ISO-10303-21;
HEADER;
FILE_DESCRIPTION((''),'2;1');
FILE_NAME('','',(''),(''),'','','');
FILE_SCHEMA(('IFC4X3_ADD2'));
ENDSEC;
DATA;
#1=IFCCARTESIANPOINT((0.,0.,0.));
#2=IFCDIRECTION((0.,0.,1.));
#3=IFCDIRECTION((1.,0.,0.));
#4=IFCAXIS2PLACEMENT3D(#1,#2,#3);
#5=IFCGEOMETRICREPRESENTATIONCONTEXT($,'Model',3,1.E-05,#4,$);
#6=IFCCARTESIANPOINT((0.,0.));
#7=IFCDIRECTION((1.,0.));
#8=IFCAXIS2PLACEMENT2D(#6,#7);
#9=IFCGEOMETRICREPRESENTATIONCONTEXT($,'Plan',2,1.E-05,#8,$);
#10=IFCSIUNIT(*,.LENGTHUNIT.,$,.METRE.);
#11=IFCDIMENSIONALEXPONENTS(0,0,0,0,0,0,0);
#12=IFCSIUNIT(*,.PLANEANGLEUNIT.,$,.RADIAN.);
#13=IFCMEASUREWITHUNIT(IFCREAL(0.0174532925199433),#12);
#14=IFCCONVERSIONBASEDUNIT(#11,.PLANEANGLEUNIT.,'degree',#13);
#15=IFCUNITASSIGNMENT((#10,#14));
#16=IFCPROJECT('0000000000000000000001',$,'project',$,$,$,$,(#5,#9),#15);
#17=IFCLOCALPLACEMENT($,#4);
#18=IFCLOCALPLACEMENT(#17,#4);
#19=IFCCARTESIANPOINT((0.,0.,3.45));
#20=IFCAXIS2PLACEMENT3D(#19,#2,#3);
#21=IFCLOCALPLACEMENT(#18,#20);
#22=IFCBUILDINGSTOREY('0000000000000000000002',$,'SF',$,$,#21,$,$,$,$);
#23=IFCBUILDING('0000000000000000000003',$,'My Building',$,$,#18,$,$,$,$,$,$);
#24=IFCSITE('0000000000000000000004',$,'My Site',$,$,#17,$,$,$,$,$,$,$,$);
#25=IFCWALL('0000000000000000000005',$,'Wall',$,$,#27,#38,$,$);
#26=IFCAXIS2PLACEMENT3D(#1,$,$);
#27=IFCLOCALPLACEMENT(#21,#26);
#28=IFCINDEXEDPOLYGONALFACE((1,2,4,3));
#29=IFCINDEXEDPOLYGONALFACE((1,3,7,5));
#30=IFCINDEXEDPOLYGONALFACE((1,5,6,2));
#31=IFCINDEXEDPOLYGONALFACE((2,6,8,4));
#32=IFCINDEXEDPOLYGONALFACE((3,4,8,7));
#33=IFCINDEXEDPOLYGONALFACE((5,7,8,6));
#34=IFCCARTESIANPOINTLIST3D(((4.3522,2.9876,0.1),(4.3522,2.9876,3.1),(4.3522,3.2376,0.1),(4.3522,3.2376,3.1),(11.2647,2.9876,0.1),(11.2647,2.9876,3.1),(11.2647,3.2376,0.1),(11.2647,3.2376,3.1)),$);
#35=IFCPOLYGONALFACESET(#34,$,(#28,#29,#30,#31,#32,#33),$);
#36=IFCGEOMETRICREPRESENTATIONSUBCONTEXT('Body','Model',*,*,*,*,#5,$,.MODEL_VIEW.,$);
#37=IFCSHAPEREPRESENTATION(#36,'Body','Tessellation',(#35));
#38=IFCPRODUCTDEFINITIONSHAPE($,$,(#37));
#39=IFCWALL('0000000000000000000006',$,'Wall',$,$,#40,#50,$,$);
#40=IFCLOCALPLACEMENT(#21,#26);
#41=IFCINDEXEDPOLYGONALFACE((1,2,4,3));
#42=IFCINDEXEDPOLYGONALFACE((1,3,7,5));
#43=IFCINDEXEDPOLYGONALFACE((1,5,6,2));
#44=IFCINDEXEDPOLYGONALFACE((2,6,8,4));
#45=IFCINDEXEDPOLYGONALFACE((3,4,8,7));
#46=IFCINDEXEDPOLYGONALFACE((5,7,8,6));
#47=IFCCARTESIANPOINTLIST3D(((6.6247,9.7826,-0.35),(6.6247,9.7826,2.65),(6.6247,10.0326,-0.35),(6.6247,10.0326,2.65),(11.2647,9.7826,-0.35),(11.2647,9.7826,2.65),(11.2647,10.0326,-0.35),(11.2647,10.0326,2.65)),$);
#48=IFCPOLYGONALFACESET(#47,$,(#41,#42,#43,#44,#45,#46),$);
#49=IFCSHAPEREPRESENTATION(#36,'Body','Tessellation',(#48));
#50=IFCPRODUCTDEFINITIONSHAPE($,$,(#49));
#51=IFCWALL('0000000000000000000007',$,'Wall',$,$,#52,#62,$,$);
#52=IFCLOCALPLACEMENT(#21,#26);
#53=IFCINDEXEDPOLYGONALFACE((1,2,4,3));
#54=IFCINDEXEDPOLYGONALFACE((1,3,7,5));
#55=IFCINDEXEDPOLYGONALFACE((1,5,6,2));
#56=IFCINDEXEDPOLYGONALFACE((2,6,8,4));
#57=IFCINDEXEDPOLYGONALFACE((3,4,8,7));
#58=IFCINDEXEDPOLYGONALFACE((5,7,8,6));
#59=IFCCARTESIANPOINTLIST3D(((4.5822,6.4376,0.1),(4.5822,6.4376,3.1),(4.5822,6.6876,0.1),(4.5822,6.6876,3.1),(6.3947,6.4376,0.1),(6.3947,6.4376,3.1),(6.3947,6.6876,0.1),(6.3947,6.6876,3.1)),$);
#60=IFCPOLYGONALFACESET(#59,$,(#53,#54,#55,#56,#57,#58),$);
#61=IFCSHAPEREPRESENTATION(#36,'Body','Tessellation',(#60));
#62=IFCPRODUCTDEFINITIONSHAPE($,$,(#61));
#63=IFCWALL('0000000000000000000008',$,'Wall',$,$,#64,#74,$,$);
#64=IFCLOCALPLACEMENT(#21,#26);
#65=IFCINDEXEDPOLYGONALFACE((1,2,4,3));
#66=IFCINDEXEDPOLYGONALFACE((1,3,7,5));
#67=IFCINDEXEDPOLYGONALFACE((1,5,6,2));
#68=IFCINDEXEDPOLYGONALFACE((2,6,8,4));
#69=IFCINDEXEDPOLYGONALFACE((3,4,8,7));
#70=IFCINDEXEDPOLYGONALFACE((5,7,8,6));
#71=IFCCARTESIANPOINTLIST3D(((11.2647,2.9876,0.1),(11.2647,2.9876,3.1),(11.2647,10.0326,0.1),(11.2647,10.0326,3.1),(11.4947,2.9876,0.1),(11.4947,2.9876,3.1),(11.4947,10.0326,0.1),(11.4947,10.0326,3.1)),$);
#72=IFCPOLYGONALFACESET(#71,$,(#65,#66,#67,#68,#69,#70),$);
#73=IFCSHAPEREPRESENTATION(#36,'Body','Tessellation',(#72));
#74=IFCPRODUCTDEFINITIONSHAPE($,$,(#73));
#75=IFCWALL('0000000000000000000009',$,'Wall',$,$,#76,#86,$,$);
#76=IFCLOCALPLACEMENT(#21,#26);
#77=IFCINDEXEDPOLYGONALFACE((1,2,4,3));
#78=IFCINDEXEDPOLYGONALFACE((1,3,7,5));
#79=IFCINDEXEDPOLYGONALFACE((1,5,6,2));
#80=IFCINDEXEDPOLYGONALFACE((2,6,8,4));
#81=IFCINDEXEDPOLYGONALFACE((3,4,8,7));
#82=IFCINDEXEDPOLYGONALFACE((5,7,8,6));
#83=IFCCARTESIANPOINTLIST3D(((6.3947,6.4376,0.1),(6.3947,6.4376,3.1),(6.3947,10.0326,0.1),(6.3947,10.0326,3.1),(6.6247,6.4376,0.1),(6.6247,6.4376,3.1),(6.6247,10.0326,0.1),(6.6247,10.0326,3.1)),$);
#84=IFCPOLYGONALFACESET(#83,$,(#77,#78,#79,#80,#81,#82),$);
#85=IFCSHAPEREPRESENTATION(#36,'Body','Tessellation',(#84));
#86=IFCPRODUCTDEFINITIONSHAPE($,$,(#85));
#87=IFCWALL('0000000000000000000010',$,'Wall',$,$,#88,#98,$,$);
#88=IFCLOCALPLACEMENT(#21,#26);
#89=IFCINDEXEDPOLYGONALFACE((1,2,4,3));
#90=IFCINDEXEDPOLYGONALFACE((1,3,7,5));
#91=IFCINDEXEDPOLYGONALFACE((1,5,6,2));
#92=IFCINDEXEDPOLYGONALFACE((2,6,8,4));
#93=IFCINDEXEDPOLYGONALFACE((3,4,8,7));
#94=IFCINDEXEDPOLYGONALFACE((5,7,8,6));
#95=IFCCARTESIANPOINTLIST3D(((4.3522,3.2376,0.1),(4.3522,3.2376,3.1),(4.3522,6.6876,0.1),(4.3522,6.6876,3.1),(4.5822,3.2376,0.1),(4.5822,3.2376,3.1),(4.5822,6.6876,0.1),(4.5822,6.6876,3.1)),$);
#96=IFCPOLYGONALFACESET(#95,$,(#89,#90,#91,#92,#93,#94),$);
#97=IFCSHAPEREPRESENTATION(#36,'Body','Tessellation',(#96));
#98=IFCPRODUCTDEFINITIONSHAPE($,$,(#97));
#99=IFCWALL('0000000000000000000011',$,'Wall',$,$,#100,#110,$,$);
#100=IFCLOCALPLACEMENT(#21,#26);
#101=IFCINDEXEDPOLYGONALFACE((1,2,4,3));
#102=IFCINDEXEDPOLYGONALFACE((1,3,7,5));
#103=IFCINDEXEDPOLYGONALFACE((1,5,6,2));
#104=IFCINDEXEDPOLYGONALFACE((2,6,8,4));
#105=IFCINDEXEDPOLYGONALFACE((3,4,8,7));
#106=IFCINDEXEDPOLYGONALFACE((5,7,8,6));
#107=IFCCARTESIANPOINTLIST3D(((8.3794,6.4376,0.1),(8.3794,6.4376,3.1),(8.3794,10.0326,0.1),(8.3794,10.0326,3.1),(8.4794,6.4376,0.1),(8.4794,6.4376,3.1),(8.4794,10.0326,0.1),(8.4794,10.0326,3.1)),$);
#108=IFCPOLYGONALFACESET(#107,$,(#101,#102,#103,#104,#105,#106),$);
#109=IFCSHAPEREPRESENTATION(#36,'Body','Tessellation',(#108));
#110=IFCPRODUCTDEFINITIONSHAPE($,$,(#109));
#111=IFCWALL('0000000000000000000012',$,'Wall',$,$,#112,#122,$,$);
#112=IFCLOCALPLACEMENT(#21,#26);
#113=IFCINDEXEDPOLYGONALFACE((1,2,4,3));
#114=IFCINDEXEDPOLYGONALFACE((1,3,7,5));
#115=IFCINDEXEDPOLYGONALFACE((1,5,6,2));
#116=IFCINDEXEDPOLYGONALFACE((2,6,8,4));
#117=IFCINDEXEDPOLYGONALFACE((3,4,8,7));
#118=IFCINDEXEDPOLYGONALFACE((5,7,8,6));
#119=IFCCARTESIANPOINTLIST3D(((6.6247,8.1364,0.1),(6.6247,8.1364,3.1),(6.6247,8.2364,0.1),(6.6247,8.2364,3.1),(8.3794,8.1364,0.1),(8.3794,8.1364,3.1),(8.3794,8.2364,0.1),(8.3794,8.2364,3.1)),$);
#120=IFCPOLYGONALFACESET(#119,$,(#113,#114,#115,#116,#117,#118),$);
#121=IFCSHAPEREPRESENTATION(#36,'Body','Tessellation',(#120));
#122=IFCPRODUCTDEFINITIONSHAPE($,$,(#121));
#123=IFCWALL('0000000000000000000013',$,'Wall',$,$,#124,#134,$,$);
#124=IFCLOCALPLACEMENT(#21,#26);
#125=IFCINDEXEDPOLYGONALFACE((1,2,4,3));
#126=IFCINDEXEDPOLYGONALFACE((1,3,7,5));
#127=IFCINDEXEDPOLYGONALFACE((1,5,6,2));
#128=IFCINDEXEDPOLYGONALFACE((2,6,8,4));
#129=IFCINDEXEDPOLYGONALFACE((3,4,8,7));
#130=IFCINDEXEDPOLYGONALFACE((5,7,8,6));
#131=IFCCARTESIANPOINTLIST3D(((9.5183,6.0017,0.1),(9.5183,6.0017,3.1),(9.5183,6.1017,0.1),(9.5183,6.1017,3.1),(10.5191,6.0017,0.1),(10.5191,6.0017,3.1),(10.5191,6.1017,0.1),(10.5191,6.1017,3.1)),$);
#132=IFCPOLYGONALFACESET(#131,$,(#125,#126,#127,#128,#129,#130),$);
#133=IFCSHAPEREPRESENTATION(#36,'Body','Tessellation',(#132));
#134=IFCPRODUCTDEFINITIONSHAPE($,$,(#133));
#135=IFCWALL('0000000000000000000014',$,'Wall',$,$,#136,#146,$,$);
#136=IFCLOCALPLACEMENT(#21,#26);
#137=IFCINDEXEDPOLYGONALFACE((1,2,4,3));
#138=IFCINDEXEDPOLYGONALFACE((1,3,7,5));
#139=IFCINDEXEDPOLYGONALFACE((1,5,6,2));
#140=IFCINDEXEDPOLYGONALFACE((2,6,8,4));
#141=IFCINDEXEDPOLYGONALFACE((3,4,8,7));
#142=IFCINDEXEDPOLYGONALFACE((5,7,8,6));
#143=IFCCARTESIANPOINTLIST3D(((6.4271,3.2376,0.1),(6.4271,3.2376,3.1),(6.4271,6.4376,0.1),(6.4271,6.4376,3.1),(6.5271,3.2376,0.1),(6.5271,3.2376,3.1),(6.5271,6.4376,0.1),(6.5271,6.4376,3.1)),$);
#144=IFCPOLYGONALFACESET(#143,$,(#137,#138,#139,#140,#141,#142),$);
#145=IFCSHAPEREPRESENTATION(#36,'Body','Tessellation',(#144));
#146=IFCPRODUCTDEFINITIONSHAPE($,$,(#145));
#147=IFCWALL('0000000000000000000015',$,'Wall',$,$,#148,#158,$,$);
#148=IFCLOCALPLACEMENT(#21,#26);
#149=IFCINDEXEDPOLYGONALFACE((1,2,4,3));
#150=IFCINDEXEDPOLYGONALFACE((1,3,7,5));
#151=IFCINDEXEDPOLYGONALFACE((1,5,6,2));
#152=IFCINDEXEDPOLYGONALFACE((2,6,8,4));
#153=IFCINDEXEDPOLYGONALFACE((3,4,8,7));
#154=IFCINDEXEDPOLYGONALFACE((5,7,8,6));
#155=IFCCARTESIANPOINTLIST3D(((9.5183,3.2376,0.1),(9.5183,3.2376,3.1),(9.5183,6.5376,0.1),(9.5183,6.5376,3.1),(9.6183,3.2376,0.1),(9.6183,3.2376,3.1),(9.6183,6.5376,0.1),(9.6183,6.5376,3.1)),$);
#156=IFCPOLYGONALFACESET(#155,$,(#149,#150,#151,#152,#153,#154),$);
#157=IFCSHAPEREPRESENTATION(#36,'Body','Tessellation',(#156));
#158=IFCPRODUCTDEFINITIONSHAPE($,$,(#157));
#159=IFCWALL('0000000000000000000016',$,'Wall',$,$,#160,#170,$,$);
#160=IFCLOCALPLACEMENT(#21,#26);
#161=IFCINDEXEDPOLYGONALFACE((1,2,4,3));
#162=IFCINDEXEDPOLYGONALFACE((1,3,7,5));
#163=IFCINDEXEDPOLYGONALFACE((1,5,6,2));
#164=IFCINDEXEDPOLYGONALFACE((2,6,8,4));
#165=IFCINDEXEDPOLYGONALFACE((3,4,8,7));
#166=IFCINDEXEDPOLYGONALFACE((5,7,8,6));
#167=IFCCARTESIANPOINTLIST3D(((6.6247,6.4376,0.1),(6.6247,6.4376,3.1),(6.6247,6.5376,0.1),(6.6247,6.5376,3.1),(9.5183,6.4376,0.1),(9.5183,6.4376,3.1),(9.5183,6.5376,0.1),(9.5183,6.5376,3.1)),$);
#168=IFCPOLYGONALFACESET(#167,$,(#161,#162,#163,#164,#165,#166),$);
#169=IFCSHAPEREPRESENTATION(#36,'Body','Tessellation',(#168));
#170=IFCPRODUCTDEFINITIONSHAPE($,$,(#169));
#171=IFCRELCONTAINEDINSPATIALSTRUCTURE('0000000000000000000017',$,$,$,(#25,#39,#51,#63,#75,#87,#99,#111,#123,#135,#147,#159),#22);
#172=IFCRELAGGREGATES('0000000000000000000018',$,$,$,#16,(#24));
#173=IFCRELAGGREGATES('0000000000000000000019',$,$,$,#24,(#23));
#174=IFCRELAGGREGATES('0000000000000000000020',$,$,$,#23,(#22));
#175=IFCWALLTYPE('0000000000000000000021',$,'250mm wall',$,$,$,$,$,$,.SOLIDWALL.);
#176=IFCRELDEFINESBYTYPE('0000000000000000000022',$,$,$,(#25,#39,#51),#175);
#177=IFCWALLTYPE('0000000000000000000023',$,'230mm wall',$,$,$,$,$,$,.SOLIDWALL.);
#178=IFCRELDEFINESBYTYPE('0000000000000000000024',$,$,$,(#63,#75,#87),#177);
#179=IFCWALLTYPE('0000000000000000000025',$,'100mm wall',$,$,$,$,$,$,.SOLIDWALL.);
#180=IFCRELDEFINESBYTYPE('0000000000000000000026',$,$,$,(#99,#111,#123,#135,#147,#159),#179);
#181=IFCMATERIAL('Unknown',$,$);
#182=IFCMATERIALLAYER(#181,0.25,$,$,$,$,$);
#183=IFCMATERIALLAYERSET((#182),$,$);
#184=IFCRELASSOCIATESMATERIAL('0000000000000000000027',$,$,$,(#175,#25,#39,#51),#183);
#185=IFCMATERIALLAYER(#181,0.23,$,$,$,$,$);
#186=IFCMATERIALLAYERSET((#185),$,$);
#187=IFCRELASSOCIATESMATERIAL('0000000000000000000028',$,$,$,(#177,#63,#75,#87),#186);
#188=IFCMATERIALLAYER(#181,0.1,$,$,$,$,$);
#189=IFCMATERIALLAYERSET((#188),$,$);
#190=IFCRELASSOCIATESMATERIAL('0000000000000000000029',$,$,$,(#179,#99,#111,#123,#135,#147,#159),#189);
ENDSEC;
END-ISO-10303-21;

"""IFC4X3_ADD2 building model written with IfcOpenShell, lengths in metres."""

from ifc_helpers import new_model, entity, si_unit, converted_unit, frame, origin_with_axes, origin_2d_with_axis, place, context, subcontext, project, spatial, indexed_curve, outline, extrude, material, layer, layer_set, layer_usage, type_object, element, save


model = new_model("IFC4X3_ADD2")

# Units and contexts
model_context = context("Model", 3, precision=1e-05, world=origin_with_axes())
plan_context = context("Plan", 2, precision=1e-05, world=origin_2d_with_axis())
body_context_1 = subcontext(model_context, "Body", "Model", "MODEL_VIEW")
ifc_project = project(units=[si_unit("LENGTHUNIT", "METRE"), converted_unit("PLANEANGLEUNIT", "degree", entity("IfcReal", 0.0174532925199433), si_unit("PLANEANGLEUNIT", "RADIAN"), dimensions=[0, 0, 0, 0, 0, 0, 0])], contexts=[model_context, plan_context])

# Site, building, storey
site_placement = place(None, origin_with_axes())
site = spatial("IfcSite", under=ifc_project, at=site_placement, Name="My Site")
building_placement = place(site_placement, origin_with_axes())
building = spatial("IfcBuilding", under=site, at=building_placement, Name="My Building")
storey_placement = place(building_placement, frame((0.0, 0.0, 3.45), z_axis=(0.0, 0.0, 1.0), x_axis=(1.0, 0.0, 0.0)))
storey = spatial("IfcBuildingStorey", under=building, at=storey_placement, Name="SF")

# Walls
ifc_material = material(Name="Unknown")
ifc_layer_1 = layer(ifc_material, 0.25)
ifc_layer_set_1 = layer_set([ifc_layer_1])
ifc_layer_usage_1 = layer_usage(ifc_layer_set_1, "AXIS2", "POSITIVE", 0.0)
wall_type_1 = type_object("IfcWallType", Name="250mm wall", PredefinedType="SOLIDWALL", material=ifc_layer_set_1)
wall_1_placement = place(storey_placement, frame((4.3522, 2.9876, 0.1), z_axis=(0.0, 0.0, 1.0), x_axis=(1.0, 0.0, 0.0)))
element("IfcWall", 1, at=wall_1_placement, inside=storey, type_object=wall_type_1, material=ifc_layer_usage_1, Name="Wall", context=body_context_1, shape_type="SweptSolid", body=[
    extrude(outline(indexed_curve([(0.0, 0.0), (0.0, 0.25), (6.9125, 0.25), (6.9125, 0.0), (0.0, 0.0)], self_intersect=False)), origin_with_axes(), (0.0, 0.0, 1.0), 3.0),
])
ifc_layer_usage_2 = layer_usage(ifc_layer_set_1, "AXIS2", "POSITIVE", 0.0)
wall_2_placement = place(storey_placement, frame((6.6247, 9.7826, -0.35), z_axis=(0.0, 0.0, 1.0), x_axis=(1.0, 0.0, 0.0)))
element("IfcWall", 2, at=wall_2_placement, inside=storey, type_object=wall_type_1, material=ifc_layer_usage_2, Name="Wall", context=body_context_1, shape_type="SweptSolid", body=[
    extrude(outline(indexed_curve([(0.0, 0.0), (0.0, 0.25), (4.64, 0.25), (4.64, 0.0), (0.0, 0.0)], self_intersect=False)), origin_with_axes(), (0.0, 0.0, 1.0), 3.0),
])
ifc_layer_usage_3 = layer_usage(ifc_layer_set_1, "AXIS2", "POSITIVE", 0.0)
wall_3_placement = place(storey_placement, frame((4.5822, 6.4376, 0.1), z_axis=(0.0, 0.0, 1.0), x_axis=(1.0, 0.0, 0.0)))
element("IfcWall", 3, at=wall_3_placement, inside=storey, type_object=wall_type_1, material=ifc_layer_usage_3, Name="Wall", context=body_context_1, shape_type="SweptSolid", body=[
    extrude(outline(indexed_curve([(0.0, 0.0), (0.0, 0.25), (1.8125, 0.25), (1.8125, 0.0), (0.0, 0.0)], self_intersect=False)), origin_with_axes(), (0.0, 0.0, 1.0), 3.0),
])
ifc_layer_2 = layer(ifc_material, 0.23)
ifc_layer_set_2 = layer_set([ifc_layer_2])
ifc_layer_usage_4 = layer_usage(ifc_layer_set_2, "AXIS2", "POSITIVE", 0.0)
wall_type_2 = type_object("IfcWallType", Name="230mm wall", PredefinedType="SOLIDWALL", material=ifc_layer_set_2)
wall_4_placement = place(storey_placement, frame((11.4947, 2.9876, 0.1), z_axis=(0.0, 0.0, 1.0), x_axis=(0.0, 1.0, 0.0)))
element("IfcWall", 4, at=wall_4_placement, inside=storey, type_object=wall_type_2, material=ifc_layer_usage_4, Name="Wall", context=body_context_1, shape_type="SweptSolid", body=[
    extrude(outline(indexed_curve([(0.0, 0.0), (0.0, 0.23), (7.045, 0.23), (7.045, 0.0), (0.0, 0.0)], self_intersect=False)), origin_with_axes(), (0.0, 0.0, 1.0), 3.0),
])
ifc_layer_usage_5 = layer_usage(ifc_layer_set_2, "AXIS2", "POSITIVE", 0.0)
wall_5_placement = place(storey_placement, frame((6.6247, 6.4376, 0.1), z_axis=(0.0, 0.0, 1.0), x_axis=(0.0, 1.0, 0.0)))
element("IfcWall", 5, at=wall_5_placement, inside=storey, type_object=wall_type_2, material=ifc_layer_usage_5, Name="Wall", context=body_context_1, shape_type="SweptSolid", body=[
    extrude(outline(indexed_curve([(0.0, 0.0), (0.0, 0.23), (3.595, 0.23), (3.595, 0.0), (0.0, 0.0)], self_intersect=False)), origin_with_axes(), (0.0, 0.0, 1.0), 3.0),
])
ifc_layer_usage_6 = layer_usage(ifc_layer_set_2, "AXIS2", "POSITIVE", 0.0)
wall_6_placement = place(storey_placement, frame((4.5822, 3.2376, 0.1), z_axis=(0.0, 0.0, 1.0), x_axis=(0.0, 1.0, 0.0)))
element("IfcWall", 6, at=wall_6_placement, inside=storey, type_object=wall_type_2, material=ifc_layer_usage_6, Name="Wall", context=body_context_1, shape_type="SweptSolid", body=[
    extrude(outline(indexed_curve([(0.0, 0.0), (0.0, 0.23), (3.45, 0.23), (3.45, 0.0), (0.0, 0.0)], self_intersect=False)), origin_with_axes(), (0.0, 0.0, 1.0), 3.0),
])
ifc_layer_3 = layer(ifc_material, 0.1)
ifc_layer_set_3 = layer_set([ifc_layer_3])
ifc_layer_usage_7 = layer_usage(ifc_layer_set_3, "AXIS2", "POSITIVE", 0.0)
wall_type_3 = type_object("IfcWallType", Name="100mm wall", PredefinedType="SOLIDWALL", material=ifc_layer_set_3)
wall_7_placement = place(storey_placement, frame((8.4794, 6.4376, 0.1), z_axis=(0.0, 0.0, 1.0), x_axis=(0.0, 1.0, 0.0)))
element("IfcWall", 7, at=wall_7_placement, inside=storey, type_object=wall_type_3, material=ifc_layer_usage_7, Name="Wall", context=body_context_1, shape_type="SweptSolid", body=[
    extrude(outline(indexed_curve([(0.0, 0.0), (0.0, 0.1), (3.595, 0.1), (3.595, 0.0), (0.0, 0.0)], self_intersect=False)), origin_with_axes(), (0.0, 0.0, 1.0), 3.0),
])
ifc_layer_usage_8 = layer_usage(ifc_layer_set_3, "AXIS2", "POSITIVE", 0.0)
wall_8_placement = place(storey_placement, frame((8.3794, 8.2364, 0.1), z_axis=(0.0, 0.0, 1.0), x_axis=(-1.0, 0.0, 0.0)))
element("IfcWall", 8, at=wall_8_placement, inside=storey, type_object=wall_type_3, material=ifc_layer_usage_8, Name="Wall", context=body_context_1, shape_type="SweptSolid", body=[
    extrude(outline(indexed_curve([(0.0, 0.0), (0.0, 0.1), (1.7547, 0.1), (1.7547, 0.0), (0.0, 0.0)], self_intersect=False)), origin_with_axes(), (0.0, 0.0, 1.0), 3.0),
])
ifc_layer_usage_9 = layer_usage(ifc_layer_set_3, "AXIS2", "POSITIVE", 0.0)
wall_9_placement = place(storey_placement, frame((10.5191, 6.1017, 0.1), z_axis=(0.0, 0.0, 1.0), x_axis=(-1.0, 0.0, 0.0)))
element("IfcWall", 9, at=wall_9_placement, inside=storey, type_object=wall_type_3, material=ifc_layer_usage_9, Name="Wall", context=body_context_1, shape_type="SweptSolid", body=[
    extrude(outline(indexed_curve([(0.0, 0.0), (0.0, 0.1), (1.0008, 0.1), (1.0008, 0.0), (0.0, 0.0)], self_intersect=False)), origin_with_axes(), (0.0, 0.0, 1.0), 3.0),
])
ifc_layer_usage_10 = layer_usage(ifc_layer_set_3, "AXIS2", "POSITIVE", 0.0)
wall_10_placement = place(storey_placement, frame((6.5271, 3.2376, 0.1), z_axis=(0.0, 0.0, 1.0), x_axis=(0.0, 1.0, 0.0)))
element("IfcWall", 10, at=wall_10_placement, inside=storey, type_object=wall_type_3, material=ifc_layer_usage_10, Name="Wall", context=body_context_1, shape_type="SweptSolid", body=[
    extrude(outline(indexed_curve([(0.0, 0.0), (0.0, 0.1), (3.2, 0.1), (3.2, 0.0), (0.0, 0.0)], self_intersect=False)), origin_with_axes(), (0.0, 0.0, 1.0), 3.0),
])
ifc_layer_usage_11 = layer_usage(ifc_layer_set_3, "AXIS2", "POSITIVE", 0.0)
wall_11_placement = place(storey_placement, frame((9.6183, 3.2376, 0.1), z_axis=(0.0, 0.0, 1.0), x_axis=(0.0, 1.0, 0.0)))
element("IfcWall", 11, at=wall_11_placement, inside=storey, type_object=wall_type_3, material=ifc_layer_usage_11, Name="Wall", context=body_context_1, shape_type="SweptSolid", body=[
    extrude(outline(indexed_curve([(0.0, 0.0), (0.0, 0.1), (3.3, 0.1), (3.3, 0.0), (0.0, 0.0)], self_intersect=False)), origin_with_axes(), (0.0, 0.0, 1.0), 3.0),
])
ifc_layer_usage_12 = layer_usage(ifc_layer_set_3, "AXIS2", "POSITIVE", 0.0)
wall_12_placement = place(storey_placement, frame((9.5183, 6.5376, 0.1), z_axis=(0.0, 0.0, 1.0), x_axis=(-1.0, 0.0, 0.0)))
element("IfcWall", 12, at=wall_12_placement, inside=storey, type_object=wall_type_3, material=ifc_layer_usage_12, Name="Wall", context=body_context_1, shape_type="SweptSolid", body=[
    extrude(outline(indexed_curve([(0.0, 0.0), (0.0, 0.1), (2.8936, 0.1), (2.8936, 0.0), (0.0, 0.0)], self_intersect=False)), origin_with_axes(), (0.0, 0.0, 1.0), 3.0),
])

save(model, "model.ifc")
